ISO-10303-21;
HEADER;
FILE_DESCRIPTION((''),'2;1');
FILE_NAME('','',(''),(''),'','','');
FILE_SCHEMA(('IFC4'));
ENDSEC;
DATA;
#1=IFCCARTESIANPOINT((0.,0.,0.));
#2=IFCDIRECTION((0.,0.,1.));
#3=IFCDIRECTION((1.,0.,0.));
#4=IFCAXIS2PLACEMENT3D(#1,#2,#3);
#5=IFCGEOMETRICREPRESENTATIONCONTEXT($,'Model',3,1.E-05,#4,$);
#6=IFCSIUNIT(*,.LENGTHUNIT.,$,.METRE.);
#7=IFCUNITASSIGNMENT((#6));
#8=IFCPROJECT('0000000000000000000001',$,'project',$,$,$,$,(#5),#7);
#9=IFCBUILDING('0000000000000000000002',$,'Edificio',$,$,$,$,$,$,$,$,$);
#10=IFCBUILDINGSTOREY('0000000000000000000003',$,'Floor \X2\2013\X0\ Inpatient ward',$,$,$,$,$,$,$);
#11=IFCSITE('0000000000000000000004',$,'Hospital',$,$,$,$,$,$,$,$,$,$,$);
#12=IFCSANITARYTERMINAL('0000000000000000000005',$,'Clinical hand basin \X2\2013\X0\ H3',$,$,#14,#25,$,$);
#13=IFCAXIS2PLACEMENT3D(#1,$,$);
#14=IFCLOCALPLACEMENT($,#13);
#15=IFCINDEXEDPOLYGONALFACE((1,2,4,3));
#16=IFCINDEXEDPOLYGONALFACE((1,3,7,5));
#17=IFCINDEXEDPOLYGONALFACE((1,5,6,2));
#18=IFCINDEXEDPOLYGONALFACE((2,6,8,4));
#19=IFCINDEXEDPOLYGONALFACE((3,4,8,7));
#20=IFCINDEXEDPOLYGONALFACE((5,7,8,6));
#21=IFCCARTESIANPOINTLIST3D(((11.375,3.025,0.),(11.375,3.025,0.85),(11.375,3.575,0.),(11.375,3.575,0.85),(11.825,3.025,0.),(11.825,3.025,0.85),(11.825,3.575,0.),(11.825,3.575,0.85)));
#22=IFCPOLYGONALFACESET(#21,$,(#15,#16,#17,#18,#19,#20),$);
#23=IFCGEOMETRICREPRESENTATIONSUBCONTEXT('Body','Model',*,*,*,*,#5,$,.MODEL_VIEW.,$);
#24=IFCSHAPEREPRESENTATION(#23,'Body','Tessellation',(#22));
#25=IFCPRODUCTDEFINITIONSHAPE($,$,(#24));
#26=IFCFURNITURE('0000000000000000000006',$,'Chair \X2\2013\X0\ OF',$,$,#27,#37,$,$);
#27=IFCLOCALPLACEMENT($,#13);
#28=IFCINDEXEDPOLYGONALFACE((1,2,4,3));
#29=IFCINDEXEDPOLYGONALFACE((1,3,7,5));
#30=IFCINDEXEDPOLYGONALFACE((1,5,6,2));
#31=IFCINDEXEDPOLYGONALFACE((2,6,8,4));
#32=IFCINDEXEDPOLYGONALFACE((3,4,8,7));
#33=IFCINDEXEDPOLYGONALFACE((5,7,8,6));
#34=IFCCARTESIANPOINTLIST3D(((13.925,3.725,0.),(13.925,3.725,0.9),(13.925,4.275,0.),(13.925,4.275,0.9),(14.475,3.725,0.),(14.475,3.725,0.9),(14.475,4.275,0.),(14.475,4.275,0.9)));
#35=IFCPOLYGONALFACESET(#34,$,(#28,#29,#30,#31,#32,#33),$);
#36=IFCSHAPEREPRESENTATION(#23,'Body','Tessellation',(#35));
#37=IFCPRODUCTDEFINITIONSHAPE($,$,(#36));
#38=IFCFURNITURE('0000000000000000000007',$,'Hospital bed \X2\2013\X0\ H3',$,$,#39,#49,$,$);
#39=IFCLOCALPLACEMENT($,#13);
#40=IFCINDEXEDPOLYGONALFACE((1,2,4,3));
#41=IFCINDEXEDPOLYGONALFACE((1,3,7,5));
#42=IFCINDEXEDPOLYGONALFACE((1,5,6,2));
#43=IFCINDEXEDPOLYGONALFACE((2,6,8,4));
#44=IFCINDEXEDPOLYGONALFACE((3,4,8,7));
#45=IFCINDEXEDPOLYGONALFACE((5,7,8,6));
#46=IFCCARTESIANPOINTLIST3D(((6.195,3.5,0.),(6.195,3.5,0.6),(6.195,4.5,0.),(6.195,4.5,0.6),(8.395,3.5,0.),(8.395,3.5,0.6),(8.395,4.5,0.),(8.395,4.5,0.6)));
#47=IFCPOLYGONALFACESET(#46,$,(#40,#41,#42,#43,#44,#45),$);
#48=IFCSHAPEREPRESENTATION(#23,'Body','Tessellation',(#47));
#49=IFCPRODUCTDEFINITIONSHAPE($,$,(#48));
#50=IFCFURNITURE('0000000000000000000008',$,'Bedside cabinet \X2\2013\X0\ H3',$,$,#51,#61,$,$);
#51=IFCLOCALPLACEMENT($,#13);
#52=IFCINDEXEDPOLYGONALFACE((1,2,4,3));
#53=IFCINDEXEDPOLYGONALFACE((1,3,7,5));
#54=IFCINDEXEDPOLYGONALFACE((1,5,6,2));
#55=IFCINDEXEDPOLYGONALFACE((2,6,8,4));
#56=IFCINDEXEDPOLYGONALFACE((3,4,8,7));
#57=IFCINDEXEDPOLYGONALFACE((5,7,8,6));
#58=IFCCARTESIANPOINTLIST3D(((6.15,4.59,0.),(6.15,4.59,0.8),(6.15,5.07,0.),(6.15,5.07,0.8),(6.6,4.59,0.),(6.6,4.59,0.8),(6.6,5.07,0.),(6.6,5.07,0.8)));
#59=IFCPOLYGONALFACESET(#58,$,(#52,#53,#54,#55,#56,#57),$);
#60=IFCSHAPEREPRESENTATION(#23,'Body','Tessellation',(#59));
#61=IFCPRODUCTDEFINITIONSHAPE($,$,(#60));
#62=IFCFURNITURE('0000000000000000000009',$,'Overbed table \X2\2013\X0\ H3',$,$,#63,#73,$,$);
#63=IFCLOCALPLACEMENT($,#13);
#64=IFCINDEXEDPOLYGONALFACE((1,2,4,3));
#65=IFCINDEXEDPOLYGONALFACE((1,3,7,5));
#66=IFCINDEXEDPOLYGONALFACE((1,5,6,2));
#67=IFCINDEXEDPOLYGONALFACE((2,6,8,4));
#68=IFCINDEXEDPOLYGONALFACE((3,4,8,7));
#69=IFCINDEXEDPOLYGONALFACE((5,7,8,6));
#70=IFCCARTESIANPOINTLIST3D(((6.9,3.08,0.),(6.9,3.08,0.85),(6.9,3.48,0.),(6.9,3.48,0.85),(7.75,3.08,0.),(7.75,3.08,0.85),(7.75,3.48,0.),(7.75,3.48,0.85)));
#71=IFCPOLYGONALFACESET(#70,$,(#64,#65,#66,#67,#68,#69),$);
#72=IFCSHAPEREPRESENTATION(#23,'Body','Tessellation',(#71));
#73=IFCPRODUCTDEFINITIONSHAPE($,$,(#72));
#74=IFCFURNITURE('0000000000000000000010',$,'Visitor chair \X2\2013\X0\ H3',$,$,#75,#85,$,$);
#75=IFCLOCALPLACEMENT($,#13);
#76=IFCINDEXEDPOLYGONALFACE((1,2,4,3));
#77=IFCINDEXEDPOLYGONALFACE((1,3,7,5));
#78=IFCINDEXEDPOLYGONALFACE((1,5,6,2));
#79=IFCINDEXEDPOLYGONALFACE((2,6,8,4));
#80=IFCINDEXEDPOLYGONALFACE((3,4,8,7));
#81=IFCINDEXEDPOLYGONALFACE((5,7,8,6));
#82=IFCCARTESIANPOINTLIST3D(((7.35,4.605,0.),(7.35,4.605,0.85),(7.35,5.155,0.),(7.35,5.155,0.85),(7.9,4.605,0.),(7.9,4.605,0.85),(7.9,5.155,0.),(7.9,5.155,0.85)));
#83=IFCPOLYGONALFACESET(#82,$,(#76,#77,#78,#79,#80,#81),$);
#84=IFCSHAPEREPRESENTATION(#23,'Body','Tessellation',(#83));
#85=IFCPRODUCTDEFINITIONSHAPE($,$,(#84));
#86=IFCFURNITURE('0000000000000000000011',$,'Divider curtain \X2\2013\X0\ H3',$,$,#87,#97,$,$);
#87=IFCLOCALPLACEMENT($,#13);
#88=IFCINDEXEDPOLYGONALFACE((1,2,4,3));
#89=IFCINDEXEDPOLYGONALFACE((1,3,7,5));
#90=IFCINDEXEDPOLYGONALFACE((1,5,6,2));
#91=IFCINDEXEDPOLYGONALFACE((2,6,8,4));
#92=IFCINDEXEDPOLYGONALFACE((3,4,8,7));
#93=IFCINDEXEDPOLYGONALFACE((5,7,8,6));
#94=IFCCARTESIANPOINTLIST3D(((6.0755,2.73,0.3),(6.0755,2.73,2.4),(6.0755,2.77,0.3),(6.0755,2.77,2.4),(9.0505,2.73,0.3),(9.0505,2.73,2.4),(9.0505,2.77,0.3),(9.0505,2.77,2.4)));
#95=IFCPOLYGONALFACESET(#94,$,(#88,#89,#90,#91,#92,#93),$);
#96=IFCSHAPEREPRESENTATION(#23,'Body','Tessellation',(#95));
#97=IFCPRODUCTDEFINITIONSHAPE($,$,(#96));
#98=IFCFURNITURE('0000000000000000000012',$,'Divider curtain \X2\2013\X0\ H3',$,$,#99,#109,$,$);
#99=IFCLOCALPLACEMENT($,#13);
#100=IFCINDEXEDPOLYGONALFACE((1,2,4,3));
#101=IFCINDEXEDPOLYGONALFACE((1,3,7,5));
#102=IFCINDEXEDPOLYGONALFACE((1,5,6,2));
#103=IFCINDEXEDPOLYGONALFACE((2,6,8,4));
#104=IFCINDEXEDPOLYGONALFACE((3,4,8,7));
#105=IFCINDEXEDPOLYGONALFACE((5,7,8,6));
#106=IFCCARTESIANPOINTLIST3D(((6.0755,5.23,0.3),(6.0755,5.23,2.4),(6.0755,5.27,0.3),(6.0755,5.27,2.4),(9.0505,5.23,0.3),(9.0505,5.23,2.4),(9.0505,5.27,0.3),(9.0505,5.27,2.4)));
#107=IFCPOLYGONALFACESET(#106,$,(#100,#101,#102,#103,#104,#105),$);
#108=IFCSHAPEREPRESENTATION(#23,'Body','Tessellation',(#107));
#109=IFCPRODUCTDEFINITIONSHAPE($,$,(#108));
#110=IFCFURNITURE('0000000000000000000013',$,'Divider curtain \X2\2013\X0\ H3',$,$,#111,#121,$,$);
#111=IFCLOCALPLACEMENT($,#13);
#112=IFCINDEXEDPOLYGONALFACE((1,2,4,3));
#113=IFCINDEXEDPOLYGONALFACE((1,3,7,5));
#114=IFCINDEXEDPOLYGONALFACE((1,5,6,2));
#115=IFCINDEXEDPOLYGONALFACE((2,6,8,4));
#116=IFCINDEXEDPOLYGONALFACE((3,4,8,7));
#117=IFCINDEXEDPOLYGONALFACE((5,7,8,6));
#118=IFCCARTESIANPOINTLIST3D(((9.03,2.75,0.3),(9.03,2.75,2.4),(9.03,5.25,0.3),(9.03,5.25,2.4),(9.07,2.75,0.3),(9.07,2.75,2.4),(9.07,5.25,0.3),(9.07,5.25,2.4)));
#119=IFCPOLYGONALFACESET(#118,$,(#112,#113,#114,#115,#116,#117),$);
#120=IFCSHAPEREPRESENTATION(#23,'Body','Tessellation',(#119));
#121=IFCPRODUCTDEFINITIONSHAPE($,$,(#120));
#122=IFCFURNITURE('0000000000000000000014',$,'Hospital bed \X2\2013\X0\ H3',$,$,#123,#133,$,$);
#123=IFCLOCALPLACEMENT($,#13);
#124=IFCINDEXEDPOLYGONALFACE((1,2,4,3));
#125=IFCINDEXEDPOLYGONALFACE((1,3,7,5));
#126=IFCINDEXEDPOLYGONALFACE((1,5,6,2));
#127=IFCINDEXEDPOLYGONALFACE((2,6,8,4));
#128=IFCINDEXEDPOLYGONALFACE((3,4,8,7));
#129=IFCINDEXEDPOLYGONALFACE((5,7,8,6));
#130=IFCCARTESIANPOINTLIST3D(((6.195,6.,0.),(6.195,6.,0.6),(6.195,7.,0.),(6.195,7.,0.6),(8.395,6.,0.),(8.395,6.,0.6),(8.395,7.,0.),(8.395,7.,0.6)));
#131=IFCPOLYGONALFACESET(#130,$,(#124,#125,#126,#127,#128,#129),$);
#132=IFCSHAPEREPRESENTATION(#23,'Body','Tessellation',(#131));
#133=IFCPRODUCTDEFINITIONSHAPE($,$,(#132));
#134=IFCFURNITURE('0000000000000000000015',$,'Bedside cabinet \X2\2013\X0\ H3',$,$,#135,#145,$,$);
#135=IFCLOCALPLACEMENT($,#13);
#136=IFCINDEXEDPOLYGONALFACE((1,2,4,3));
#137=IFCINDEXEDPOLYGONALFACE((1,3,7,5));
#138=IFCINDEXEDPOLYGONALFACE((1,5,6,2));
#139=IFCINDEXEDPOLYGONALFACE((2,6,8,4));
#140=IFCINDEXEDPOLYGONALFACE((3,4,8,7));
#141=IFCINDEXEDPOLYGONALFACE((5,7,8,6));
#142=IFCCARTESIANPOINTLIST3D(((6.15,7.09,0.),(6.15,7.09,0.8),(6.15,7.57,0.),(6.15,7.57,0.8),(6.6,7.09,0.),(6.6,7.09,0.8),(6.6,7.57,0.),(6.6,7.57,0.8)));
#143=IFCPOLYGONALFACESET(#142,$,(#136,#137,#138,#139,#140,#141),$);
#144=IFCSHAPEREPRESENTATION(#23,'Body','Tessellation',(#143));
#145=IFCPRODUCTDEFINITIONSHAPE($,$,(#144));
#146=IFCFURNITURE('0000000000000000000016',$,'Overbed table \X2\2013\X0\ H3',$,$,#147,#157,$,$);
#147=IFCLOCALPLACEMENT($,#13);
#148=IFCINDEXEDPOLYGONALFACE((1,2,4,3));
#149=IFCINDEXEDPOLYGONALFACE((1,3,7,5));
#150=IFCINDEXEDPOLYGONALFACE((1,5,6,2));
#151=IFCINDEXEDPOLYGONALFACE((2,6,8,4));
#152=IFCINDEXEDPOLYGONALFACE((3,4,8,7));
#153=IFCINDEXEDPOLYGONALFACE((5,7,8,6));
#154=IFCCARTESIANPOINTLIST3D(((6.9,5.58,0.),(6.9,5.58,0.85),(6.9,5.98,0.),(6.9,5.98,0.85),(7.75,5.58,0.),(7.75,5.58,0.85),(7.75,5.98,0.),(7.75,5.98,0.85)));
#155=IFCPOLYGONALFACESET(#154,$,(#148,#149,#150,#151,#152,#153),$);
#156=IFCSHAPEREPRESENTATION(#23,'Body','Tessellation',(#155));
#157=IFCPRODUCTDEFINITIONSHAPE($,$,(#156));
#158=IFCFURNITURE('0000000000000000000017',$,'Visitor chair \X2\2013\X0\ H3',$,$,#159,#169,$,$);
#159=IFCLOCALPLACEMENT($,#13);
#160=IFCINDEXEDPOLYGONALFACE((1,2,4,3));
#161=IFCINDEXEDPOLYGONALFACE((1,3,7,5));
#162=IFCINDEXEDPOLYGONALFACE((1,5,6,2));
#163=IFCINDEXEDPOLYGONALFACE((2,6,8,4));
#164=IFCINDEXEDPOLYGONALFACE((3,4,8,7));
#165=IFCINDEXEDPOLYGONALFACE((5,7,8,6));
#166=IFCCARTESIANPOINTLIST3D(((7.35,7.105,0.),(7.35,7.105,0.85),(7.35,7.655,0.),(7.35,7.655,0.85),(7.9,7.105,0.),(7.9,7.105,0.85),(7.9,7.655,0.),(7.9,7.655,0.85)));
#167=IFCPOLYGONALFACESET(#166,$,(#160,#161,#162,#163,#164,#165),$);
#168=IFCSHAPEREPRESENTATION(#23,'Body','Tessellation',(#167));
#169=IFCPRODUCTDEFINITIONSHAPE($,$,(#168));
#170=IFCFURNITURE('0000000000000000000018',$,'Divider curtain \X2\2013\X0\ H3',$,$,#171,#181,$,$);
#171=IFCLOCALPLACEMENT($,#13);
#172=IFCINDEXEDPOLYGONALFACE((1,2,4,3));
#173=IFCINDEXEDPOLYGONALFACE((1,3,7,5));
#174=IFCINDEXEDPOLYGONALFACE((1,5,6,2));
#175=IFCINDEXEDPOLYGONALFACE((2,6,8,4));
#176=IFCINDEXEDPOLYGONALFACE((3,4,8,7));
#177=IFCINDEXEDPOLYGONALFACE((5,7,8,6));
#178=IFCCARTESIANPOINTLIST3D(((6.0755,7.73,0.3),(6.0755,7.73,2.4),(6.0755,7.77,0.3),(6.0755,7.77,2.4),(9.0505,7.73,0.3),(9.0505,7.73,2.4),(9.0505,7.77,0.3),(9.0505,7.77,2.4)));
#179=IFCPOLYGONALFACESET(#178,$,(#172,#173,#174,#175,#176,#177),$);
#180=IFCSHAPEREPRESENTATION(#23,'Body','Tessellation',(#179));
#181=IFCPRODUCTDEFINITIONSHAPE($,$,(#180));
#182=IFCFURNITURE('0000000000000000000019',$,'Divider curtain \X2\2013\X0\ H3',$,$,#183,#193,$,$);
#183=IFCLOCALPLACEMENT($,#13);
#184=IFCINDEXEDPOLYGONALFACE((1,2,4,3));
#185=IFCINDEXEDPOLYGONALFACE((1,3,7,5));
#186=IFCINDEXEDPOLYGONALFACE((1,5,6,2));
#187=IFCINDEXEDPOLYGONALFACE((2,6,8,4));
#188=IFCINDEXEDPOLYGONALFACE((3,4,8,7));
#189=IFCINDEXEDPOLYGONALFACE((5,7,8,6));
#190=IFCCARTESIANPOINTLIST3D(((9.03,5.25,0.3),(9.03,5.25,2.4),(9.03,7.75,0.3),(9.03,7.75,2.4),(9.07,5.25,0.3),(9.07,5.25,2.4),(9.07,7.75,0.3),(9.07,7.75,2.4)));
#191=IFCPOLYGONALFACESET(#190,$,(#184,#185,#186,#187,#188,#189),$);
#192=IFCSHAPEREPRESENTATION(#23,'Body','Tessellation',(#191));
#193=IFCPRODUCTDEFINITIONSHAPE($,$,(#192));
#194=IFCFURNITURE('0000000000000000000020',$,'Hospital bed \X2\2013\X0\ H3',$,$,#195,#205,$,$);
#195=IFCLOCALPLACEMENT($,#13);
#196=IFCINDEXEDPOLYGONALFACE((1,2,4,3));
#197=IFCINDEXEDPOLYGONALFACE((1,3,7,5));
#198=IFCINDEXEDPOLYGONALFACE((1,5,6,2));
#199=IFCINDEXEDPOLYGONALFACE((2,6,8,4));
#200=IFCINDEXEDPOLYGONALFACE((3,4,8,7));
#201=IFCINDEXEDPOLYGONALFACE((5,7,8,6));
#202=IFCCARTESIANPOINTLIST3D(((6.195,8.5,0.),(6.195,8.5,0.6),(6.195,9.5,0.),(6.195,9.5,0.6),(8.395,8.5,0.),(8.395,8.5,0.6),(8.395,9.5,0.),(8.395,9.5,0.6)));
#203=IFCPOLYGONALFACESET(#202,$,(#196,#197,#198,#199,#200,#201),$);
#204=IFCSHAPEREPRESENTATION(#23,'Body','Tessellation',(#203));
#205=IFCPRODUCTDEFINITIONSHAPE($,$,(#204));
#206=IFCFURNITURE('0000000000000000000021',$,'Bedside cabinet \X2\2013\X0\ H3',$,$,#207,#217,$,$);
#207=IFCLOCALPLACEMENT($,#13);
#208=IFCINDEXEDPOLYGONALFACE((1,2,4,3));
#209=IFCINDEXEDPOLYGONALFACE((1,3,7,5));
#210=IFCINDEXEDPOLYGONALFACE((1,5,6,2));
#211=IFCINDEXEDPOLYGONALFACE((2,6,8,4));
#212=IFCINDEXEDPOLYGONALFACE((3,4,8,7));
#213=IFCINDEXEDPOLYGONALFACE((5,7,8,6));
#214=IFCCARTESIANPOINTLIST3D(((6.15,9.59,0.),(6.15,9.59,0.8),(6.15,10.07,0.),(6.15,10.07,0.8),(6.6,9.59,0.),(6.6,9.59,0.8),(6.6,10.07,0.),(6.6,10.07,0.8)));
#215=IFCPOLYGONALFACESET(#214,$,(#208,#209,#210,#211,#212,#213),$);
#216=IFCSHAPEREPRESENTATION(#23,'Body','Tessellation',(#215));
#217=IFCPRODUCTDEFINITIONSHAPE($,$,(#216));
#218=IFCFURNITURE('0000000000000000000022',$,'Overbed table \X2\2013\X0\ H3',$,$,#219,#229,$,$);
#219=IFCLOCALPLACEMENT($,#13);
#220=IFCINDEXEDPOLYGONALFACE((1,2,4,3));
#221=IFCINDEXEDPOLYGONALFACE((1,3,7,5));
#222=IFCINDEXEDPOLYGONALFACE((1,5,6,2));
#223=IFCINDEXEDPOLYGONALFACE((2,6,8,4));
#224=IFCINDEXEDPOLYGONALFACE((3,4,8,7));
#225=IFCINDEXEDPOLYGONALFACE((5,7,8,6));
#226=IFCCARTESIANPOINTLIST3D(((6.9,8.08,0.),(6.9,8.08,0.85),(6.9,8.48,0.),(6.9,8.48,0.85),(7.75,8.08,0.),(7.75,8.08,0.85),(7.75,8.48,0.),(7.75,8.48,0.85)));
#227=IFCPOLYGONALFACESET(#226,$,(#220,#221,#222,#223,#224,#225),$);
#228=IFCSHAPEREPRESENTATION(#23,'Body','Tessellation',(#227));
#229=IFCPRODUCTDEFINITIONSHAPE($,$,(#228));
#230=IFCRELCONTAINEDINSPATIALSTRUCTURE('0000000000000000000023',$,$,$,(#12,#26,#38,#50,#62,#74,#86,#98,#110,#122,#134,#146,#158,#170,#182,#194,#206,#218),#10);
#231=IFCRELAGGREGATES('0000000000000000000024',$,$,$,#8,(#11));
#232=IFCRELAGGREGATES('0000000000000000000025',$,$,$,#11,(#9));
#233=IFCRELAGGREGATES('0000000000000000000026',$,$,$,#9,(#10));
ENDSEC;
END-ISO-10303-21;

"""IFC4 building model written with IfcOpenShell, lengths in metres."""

from ifc_helpers import new_model, si_unit, frame, origin_with_axes, context, subcontext, project, spatial, line, indexed_curve, outline, extrude, element, save


model = new_model("IFC4")

# Units and contexts
model_context = context("Model", 3, precision=1e-05, world=origin_with_axes())
body_context = subcontext(model_context, "Body", "Model", "MODEL_VIEW")
ifc_project = project(units=[si_unit("LENGTHUNIT", "METRE")], contexts=[model_context])

# Site, building, storey
site = spatial("IfcSite", under=ifc_project, Name="Hospital")
building = spatial("IfcBuilding", under=site, Name="Edificio")
storey = spatial("IfcBuildingStorey", under=building, Name="Floor – Inpatient ward")

# Sanitary terminal
element("IfcSanitaryTerminal", 1, inside=storey, Name="Clinical hand basin – H3", context=body_context, shape_type="SweptSolid", body=[
    extrude(outline(indexed_curve([(0.0, 0.0), (0.45, 0.0), (0.45, 0.55), (0.0, 0.55)], segments=[line(1, 2, 3, 4, 1)])), frame((11.375, 3.025, 0.0), z_axis=(0.0, 0.0, 1.0), x_axis=(1.0, 0.0, 0.0)), (0.0, 0.0, 1.0), 0.85),
])

# Furniture
element("IfcFurniture", 2, inside=storey, Name="Chair – OF", context=body_context, shape_type="SweptSolid", body=[
    extrude(outline(indexed_curve([(0.0, 0.0), (0.55, 0.0), (0.55, 0.55), (0.0, 0.55)], segments=[line(1, 2, 3, 4, 1)])), frame((13.925, 3.725, 0.0), z_axis=(0.0, 0.0, 1.0), x_axis=(1.0, 0.0, 0.0)), (0.0, 0.0, 1.0), 0.9),
])
element("IfcFurniture", 3, inside=storey, Name="Hospital bed – H3", context=body_context, shape_type="SweptSolid", body=[
    extrude(outline(indexed_curve([(0.0, 0.0), (2.2, 0.0), (2.2, 1.0), (0.0, 1.0)], segments=[line(1, 2, 3, 4, 1)])), frame((6.195, 3.5, 0.0), z_axis=(0.0, 0.0, 1.0), x_axis=(1.0, 0.0, 0.0)), (0.0, 0.0, 1.0), 0.6),
])
element("IfcFurniture", 4, inside=storey, Name="Bedside cabinet – H3", context=body_context, shape_type="SweptSolid", body=[
    extrude(outline(indexed_curve([(0.0, 0.0), (0.45, 0.0), (0.45, 0.48), (0.0, 0.48)], segments=[line(1, 2, 3, 4, 1)])), frame((6.15, 4.59, 0.0), z_axis=(0.0, 0.0, 1.0), x_axis=(1.0, 0.0, 0.0)), (0.0, 0.0, 1.0), 0.8),
])
element("IfcFurniture", 5, inside=storey, Name="Overbed table – H3", context=body_context, shape_type="SweptSolid", body=[
    extrude(outline(indexed_curve([(0.0, 0.0), (0.85, 0.0), (0.85, 0.4), (0.0, 0.4)], segments=[line(1, 2, 3, 4, 1)])), frame((6.9, 3.08, 0.0), z_axis=(0.0, 0.0, 1.0), x_axis=(1.0, 0.0, 0.0)), (0.0, 0.0, 1.0), 0.85),
])
element("IfcFurniture", 6, inside=storey, Name="Visitor chair – H3", context=body_context, shape_type="SweptSolid", body=[
    extrude(outline(indexed_curve([(0.0, 0.0), (0.55, 0.0), (0.55, 0.55), (0.0, 0.55)], segments=[line(1, 2, 3, 4, 1)])), frame((7.35, 4.605, 0.0), z_axis=(0.0, 0.0, 1.0), x_axis=(1.0, 0.0, 0.0)), (0.0, 0.0, 1.0), 0.85),
])
element("IfcFurniture", 7, inside=storey, Name="Divider curtain – H3", context=body_context, shape_type="SweptSolid", body=[
    extrude(outline(indexed_curve([(0.0, 0.0), (2.975, 0.0), (2.975, 0.04), (0.0, 0.04)], segments=[line(1, 2, 3, 4, 1)])), frame((6.0755, 2.73, 0.3), z_axis=(0.0, 0.0, 1.0), x_axis=(1.0, 0.0, 0.0)), (0.0, 0.0, 1.0), 2.1),
])
element("IfcFurniture", 8, inside=storey, Name="Divider curtain – H3", context=body_context, shape_type="SweptSolid", body=[
    extrude(outline(indexed_curve([(0.0, 0.0), (2.975, 0.0), (2.975, 0.04), (0.0, 0.04)], segments=[line(1, 2, 3, 4, 1)])), frame((6.0755, 5.23, 0.3), z_axis=(0.0, 0.0, 1.0), x_axis=(1.0, 0.0, 0.0)), (0.0, 0.0, 1.0), 2.1),
])
element("IfcFurniture", 9, inside=storey, Name="Divider curtain – H3", context=body_context, shape_type="SweptSolid", body=[
    extrude(outline(indexed_curve([(0.0, 0.0), (0.04, 0.0), (0.04, 2.5), (0.0, 2.5)], segments=[line(1, 2, 3, 4, 1)])), frame((9.03, 2.75, 0.3), z_axis=(0.0, 0.0, 1.0), x_axis=(1.0, 0.0, 0.0)), (0.0, 0.0, 1.0), 2.1),
])
element("IfcFurniture", 10, inside=storey, Name="Hospital bed – H3", context=body_context, shape_type="SweptSolid", body=[
    extrude(outline(indexed_curve([(0.0, 0.0), (2.2, 0.0), (2.2, 1.0), (0.0, 1.0)], segments=[line(1, 2, 3, 4, 1)])), frame((6.195, 6.0, 0.0), z_axis=(0.0, 0.0, 1.0), x_axis=(1.0, 0.0, 0.0)), (0.0, 0.0, 1.0), 0.6),
])
element("IfcFurniture", 11, inside=storey, Name="Bedside cabinet – H3", context=body_context, shape_type="SweptSolid", body=[
    extrude(outline(indexed_curve([(0.0, 0.0), (0.45, 0.0), (0.45, 0.48), (0.0, 0.48)], segments=[line(1, 2, 3, 4, 1)])), frame((6.15, 7.09, 0.0), z_axis=(0.0, 0.0, 1.0), x_axis=(1.0, 0.0, 0.0)), (0.0, 0.0, 1.0), 0.8),
])
element("IfcFurniture", 12, inside=storey, Name="Overbed table – H3", context=body_context, shape_type="SweptSolid", body=[
    extrude(outline(indexed_curve([(0.0, 0.0), (0.85, 0.0), (0.85, 0.4), (0.0, 0.4)], segments=[line(1, 2, 3, 4, 1)])), frame((6.9, 5.58, 0.0), z_axis=(0.0, 0.0, 1.0), x_axis=(1.0, 0.0, 0.0)), (0.0, 0.0, 1.0), 0.85),
])
element("IfcFurniture", 13, inside=storey, Name="Visitor chair – H3", context=body_context, shape_type="SweptSolid", body=[
    extrude(outline(indexed_curve([(0.0, 0.0), (0.55, 0.0), (0.55, 0.55), (0.0, 0.55)], segments=[line(1, 2, 3, 4, 1)])), frame((7.35, 7.105, 0.0), z_axis=(0.0, 0.0, 1.0), x_axis=(1.0, 0.0, 0.0)), (0.0, 0.0, 1.0), 0.85),
])
element("IfcFurniture", 14, inside=storey, Name="Divider curtain – H3", context=body_context, shape_type="SweptSolid", body=[
    extrude(outline(indexed_curve([(0.0, 0.0), (2.975, 0.0), (2.975, 0.04), (0.0, 0.04)], segments=[line(1, 2, 3, 4, 1)])), frame((6.0755, 7.73, 0.3), z_axis=(0.0, 0.0, 1.0), x_axis=(1.0, 0.0, 0.0)), (0.0, 0.0, 1.0), 2.1),
])
element("IfcFurniture", 15, inside=storey, Name="Divider curtain – H3", context=body_context, shape_type="SweptSolid", body=[
    extrude(outline(indexed_curve([(0.0, 0.0), (0.04, 0.0), (0.04, 2.5), (0.0, 2.5)], segments=[line(1, 2, 3, 4, 1)])), frame((9.03, 5.25, 0.3), z_axis=(0.0, 0.0, 1.0), x_axis=(1.0, 0.0, 0.0)), (0.0, 0.0, 1.0), 2.1),
])
element("IfcFurniture", 16, inside=storey, Name="Hospital bed – H3", context=body_context, shape_type="SweptSolid", body=[
    extrude(outline(indexed_curve([(0.0, 0.0), (2.2, 0.0), (2.2, 1.0), (0.0, 1.0)], segments=[line(1, 2, 3, 4, 1)])), frame((6.195, 8.5, 0.0), z_axis=(0.0, 0.0, 1.0), x_axis=(1.0, 0.0, 0.0)), (0.0, 0.0, 1.0), 0.6),
])
element("IfcFurniture", 17, inside=storey, Name="Bedside cabinet – H3", context=body_context, shape_type="SweptSolid", body=[
    extrude(outline(indexed_curve([(0.0, 0.0), (0.45, 0.0), (0.45, 0.48), (0.0, 0.48)], segments=[line(1, 2, 3, 4, 1)])), frame((6.15, 9.59, 0.0), z_axis=(0.0, 0.0, 1.0), x_axis=(1.0, 0.0, 0.0)), (0.0, 0.0, 1.0), 0.8),
])
element("IfcFurniture", 18, inside=storey, Name="Overbed table – H3", context=body_context, shape_type="SweptSolid", body=[
    extrude(outline(indexed_curve([(0.0, 0.0), (0.85, 0.0), (0.85, 0.4), (0.0, 0.4)], segments=[line(1, 2, 3, 4, 1)])), frame((6.9, 8.08, 0.0), z_axis=(0.0, 0.0, 1.0), x_axis=(1.0, 0.0, 0.0)), (0.0, 0.0, 1.0), 0.85),
])

save(model, "model.ifc")
